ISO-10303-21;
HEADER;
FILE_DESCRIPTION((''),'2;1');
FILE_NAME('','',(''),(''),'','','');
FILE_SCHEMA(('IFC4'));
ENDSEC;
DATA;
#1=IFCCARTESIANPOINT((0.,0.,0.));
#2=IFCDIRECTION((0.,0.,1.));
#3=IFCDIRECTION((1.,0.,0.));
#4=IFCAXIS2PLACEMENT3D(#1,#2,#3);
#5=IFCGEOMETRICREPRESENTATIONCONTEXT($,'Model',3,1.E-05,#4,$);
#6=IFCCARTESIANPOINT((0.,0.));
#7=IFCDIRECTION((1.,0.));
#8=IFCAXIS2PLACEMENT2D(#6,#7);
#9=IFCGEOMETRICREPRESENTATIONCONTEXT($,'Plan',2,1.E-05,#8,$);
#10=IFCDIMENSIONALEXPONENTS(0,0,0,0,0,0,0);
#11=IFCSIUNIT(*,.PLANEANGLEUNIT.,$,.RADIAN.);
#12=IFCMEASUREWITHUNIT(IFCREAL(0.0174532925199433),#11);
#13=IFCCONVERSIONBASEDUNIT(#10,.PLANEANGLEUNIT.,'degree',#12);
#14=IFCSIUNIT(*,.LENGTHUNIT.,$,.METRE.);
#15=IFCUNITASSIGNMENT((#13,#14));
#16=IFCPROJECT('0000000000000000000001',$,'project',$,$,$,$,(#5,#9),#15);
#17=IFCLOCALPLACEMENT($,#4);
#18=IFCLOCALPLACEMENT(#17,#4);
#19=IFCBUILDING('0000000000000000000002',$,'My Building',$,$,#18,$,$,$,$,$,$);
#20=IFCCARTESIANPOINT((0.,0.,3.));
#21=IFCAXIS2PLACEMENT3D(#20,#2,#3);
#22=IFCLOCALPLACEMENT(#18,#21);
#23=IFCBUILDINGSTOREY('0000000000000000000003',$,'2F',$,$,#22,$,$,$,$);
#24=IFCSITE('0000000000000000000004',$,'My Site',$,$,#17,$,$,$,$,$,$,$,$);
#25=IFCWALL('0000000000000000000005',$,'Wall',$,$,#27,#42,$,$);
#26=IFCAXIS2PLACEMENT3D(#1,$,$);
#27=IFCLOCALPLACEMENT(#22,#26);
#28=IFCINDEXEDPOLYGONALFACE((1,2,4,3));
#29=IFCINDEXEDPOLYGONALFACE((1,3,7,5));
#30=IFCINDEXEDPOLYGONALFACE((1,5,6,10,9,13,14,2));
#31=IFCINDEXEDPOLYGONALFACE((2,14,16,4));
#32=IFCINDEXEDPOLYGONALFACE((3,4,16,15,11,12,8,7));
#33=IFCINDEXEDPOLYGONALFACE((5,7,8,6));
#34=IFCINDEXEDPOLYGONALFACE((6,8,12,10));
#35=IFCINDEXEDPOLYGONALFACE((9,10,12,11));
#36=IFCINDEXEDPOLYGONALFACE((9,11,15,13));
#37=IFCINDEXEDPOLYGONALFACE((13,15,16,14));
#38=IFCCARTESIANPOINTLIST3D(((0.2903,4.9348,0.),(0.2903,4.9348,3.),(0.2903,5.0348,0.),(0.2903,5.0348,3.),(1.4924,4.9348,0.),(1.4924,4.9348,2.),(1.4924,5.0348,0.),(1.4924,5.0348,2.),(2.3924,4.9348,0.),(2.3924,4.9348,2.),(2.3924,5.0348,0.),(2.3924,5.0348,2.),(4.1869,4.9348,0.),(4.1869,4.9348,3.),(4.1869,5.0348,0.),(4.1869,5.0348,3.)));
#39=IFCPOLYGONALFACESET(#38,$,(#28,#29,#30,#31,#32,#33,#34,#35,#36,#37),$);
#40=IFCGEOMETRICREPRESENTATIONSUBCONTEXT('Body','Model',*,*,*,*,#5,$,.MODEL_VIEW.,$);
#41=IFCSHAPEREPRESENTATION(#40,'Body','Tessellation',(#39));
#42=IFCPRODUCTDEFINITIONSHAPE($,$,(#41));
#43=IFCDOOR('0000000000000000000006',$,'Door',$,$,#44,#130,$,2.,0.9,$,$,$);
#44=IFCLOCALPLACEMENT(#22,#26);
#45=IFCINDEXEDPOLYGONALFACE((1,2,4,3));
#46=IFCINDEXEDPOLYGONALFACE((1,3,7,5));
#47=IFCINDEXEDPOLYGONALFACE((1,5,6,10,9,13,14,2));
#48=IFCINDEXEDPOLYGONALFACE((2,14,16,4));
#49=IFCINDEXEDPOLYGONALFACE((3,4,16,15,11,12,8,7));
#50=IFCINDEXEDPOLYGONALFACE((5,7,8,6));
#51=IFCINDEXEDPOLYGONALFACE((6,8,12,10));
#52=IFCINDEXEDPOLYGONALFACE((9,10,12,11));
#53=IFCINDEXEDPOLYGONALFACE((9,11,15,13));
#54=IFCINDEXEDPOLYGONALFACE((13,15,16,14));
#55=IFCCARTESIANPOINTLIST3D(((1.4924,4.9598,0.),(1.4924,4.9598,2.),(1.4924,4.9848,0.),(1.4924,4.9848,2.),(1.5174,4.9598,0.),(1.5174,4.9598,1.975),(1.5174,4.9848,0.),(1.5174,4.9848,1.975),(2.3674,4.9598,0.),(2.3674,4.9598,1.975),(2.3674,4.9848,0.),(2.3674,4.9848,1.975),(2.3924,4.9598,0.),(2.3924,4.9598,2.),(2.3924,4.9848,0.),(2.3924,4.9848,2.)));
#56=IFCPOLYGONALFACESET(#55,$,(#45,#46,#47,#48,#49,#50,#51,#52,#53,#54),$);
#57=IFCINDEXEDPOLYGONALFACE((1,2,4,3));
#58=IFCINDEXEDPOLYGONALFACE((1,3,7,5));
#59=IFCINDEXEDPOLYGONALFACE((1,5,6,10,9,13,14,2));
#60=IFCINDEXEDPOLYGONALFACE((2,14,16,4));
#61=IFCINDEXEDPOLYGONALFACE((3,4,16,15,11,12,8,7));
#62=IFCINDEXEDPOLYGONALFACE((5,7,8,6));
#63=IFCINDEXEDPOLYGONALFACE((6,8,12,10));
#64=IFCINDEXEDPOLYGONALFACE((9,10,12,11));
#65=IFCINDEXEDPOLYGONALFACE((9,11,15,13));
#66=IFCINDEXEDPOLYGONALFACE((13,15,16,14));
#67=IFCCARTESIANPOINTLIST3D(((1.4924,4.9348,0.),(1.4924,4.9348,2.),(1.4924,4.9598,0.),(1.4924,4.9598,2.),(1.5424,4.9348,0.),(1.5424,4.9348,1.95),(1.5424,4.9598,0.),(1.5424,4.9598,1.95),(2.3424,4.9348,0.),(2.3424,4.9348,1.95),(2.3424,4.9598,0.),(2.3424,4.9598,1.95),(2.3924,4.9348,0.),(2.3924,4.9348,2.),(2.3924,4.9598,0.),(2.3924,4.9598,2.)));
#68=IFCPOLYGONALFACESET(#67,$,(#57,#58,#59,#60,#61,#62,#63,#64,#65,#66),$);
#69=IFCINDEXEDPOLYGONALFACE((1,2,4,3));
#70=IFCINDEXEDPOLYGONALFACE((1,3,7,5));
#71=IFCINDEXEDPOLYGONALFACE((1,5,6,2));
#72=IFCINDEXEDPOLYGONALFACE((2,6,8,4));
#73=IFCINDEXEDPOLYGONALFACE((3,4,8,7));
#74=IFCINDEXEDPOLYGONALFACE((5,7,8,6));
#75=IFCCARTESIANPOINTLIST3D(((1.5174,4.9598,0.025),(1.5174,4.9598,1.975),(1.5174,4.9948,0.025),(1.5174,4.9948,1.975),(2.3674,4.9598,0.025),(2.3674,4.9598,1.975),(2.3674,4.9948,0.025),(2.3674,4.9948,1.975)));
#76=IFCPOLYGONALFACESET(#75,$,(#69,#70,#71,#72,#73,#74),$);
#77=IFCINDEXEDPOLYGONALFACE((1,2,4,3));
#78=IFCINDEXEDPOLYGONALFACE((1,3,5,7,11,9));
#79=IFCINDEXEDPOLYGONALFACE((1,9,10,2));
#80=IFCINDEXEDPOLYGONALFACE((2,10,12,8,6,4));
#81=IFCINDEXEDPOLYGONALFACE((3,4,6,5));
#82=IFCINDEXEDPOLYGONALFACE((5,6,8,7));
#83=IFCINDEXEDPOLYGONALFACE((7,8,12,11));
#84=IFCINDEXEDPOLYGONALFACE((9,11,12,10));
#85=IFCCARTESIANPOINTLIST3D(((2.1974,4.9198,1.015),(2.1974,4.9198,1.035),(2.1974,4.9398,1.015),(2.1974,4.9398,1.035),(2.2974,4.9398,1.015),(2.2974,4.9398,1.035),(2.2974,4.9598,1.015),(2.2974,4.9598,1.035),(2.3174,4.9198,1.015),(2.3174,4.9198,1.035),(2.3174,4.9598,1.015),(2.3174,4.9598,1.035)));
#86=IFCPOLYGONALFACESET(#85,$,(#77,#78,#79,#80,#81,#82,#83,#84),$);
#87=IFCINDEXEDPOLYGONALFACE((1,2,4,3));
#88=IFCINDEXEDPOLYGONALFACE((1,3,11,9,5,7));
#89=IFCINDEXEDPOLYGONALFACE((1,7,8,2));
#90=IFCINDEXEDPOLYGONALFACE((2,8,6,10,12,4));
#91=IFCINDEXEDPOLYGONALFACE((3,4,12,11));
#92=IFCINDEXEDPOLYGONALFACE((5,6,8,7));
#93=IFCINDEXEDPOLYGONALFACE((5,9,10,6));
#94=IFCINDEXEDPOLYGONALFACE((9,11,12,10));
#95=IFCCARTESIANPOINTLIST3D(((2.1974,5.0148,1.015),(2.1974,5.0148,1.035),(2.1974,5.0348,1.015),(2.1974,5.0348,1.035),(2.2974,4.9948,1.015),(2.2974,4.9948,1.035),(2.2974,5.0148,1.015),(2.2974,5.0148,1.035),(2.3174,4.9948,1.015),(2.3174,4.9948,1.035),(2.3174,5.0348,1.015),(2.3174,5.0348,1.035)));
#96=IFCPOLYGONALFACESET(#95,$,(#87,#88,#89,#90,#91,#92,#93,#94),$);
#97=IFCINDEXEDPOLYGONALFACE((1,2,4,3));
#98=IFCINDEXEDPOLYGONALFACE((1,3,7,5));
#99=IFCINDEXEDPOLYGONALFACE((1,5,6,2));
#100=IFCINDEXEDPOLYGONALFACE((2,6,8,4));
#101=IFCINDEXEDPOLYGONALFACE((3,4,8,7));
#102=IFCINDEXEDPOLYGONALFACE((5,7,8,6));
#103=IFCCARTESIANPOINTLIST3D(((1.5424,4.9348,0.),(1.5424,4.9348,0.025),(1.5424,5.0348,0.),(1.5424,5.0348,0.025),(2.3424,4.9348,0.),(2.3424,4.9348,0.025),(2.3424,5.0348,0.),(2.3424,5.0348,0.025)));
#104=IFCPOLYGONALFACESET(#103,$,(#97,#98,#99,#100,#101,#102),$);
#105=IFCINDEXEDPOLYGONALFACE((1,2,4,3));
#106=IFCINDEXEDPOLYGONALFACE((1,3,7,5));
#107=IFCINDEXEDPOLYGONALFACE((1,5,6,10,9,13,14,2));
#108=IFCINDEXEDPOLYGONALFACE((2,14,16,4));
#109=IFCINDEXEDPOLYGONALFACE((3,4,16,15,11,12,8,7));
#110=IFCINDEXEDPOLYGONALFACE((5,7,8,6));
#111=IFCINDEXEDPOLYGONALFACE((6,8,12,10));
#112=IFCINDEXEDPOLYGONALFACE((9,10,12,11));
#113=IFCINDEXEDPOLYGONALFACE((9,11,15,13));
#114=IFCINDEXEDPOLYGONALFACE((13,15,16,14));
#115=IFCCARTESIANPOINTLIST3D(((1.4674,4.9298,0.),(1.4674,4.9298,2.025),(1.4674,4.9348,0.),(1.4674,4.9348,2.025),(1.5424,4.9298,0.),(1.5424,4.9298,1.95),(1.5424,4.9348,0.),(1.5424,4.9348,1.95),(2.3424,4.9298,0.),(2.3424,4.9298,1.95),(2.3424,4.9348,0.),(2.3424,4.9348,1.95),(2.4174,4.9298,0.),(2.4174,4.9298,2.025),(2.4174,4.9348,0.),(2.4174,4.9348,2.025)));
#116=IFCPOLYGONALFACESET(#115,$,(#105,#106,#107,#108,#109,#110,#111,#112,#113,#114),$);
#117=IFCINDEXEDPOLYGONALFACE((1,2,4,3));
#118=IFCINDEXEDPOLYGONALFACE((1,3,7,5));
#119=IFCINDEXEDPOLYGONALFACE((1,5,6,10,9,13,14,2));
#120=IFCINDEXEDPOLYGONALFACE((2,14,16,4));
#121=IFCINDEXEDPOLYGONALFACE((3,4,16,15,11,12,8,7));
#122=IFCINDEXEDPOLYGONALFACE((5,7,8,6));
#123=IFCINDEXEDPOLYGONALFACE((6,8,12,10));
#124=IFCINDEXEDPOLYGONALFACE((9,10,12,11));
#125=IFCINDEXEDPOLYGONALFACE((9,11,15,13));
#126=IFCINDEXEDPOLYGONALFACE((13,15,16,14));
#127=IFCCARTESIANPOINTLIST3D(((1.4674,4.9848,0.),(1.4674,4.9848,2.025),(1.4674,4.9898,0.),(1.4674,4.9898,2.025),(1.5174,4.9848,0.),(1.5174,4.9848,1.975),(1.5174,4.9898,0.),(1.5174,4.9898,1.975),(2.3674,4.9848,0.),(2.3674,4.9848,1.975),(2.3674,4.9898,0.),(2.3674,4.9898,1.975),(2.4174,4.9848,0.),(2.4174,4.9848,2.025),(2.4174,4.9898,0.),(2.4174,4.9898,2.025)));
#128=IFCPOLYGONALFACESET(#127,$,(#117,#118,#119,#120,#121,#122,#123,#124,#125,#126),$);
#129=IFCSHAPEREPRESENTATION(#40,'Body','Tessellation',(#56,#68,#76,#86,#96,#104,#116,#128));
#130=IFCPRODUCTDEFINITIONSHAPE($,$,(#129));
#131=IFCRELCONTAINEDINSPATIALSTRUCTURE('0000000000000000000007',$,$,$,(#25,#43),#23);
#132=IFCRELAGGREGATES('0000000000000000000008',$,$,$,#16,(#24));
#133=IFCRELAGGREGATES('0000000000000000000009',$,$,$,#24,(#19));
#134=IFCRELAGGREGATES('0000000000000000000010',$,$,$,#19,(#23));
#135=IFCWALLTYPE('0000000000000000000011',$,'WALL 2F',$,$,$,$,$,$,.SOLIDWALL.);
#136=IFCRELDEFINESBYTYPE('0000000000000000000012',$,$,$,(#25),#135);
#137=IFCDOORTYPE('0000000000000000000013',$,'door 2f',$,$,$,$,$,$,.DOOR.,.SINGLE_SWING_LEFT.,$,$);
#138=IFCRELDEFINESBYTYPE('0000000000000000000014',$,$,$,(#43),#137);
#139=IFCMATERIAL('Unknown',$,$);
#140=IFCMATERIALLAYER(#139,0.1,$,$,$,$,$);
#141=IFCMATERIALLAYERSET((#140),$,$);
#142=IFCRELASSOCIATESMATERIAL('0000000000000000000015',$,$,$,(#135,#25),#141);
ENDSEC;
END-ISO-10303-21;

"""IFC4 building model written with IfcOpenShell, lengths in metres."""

from ifc_helpers import new_model, entity, si_unit, converted_unit, frame, origin_with_axes, origin_2d_with_axis, place, context, subcontext, project, spatial, line, indexed_curve, outline, extrude, shape, source, transform, mapped, material, layer, layer_set, layer_usage, type_object, type_shapes, element, fill, save


model = new_model("IFC4")

# Units and contexts
model_context = context("Model", 3, precision=1e-05, world=origin_with_axes())
plan_context = context("Plan", 2, precision=1e-05, world=origin_2d_with_axis())
body_context_1 = subcontext(model_context, "Body", "Model", "MODEL_VIEW")
body_context_2 = subcontext(plan_context, "Body", "Plan", "PLAN_VIEW")
ifc_project = project(units=[converted_unit("PLANEANGLEUNIT", "degree", entity("IfcReal", 0.0174532925199433), si_unit("PLANEANGLEUNIT", "RADIAN"), dimensions=[0, 0, 0, 0, 0, 0, 0]), si_unit("LENGTHUNIT", "METRE")], contexts=[model_context, plan_context])

# Site, building, storey
site_placement = place(None, origin_with_axes())
site = spatial("IfcSite", under=ifc_project, at=site_placement, Name="My Site")
building_placement = place(site_placement, origin_with_axes())
building = spatial("IfcBuilding", under=site, at=building_placement, Name="My Building")
storey_placement = place(building_placement, frame((0.0, 0.0, 3.0), z_axis=(0.0, 0.0, 1.0), x_axis=(1.0, 0.0, 0.0)))
storey = spatial("IfcBuildingStorey", under=building, at=storey_placement, Name="2F")

# Shared definitions
ifc_material = material(Name="Unknown")

# Shared definitions
ifc_layer_1 = layer(ifc_material, 0.1)
ifc_layer_set_1 = layer_set([ifc_layer_1])
wall_type = type_object("IfcWallType", Name="WALL 2F", PredefinedType="SOLIDWALL", material=ifc_layer_set_1)

# Wall, opening, door
ifc_layer_usage_1 = layer_usage(ifc_layer_set_1, "AXIS2", "POSITIVE", 0.0)
wall_1_placement = place(storey_placement, frame((0.2903, 4.9348, 0.0), z_axis=(0.0, 0.0, 1.0), x_axis=(1.0, 0.0, 0.0)))
wall_1 = element("IfcWall", 1, at=wall_1_placement, inside=storey, type_object=wall_type, material=ifc_layer_usage_1, Name="Wall", context=body_context_1, shape_type="SweptSolid", body=[
    extrude(outline(indexed_curve([(0.0, 0.0), (0.0, 0.1), (3.8966, 0.1), (3.8966, 0.0)], segments=[line(1, 2, 3, 4, 1)])), origin_with_axes(), (0.0, 0.0, 1.0), 3.0),
])
shared_shape_1 = source(origin_with_axes(), body_context_1, "Body", "SweptSolid", [
    extrude(outline(indexed_curve([(0.0, 0.0), (0.9, 0.0), (0.9, 2.0), (0.0, 2.0)], segments=[line(1, 2, 3, 4, 1)])), frame((0.0, -0.6, 0.0), z_axis=(0.0, -1.0, 0.0), x_axis=(1.0, 0.0, 0.0)), (0.0, 0.0, -1.0), 1.2),
])
opening_1_placement = place(wall_1_placement, frame((1.2022, 0.0, 0.0), z_axis=(0.0, 0.0, 1.0), x_axis=(1.0, 0.0, 0.0)))
opening_1 = element("IfcOpeningElement", 2, at=opening_1_placement, cuts=wall_1, PredefinedType="OPENING", context=body_context_1, shape_type="MappedRepresentation", body=[
    mapped(shared_shape_1, transform((0.0, 0.0, 0.0), x_axis=(1.0, 0.0, 0.0), y_axis=(0.0, 1.0, 0.0), z_axis=(0.0, 0.0, 1.0), scale=1.0)),
])
door_type = type_object("IfcDoorType", Name="door 2f", OperationType="SINGLE_SWING_LEFT", PredefinedType="DOOR")
shared_shape_2 = source(origin_with_axes(), body_context_1, "Body", "SweptSolid", [
    extrude(outline(indexed_curve([(0.0, 0.0), (0.0, 2.0), (0.9, 2.0), (0.9, 0.0), (0.875, 0.0), (0.875, 1.975), (0.025, 1.975), (0.025, 0.0)], segments=[line(1, 2, 3, 4, 5, 6, 7, 8, 1)])), frame((0.0, 0.025, 0.0), z_axis=(0.0, -1.0, 0.0), x_axis=(1.0, 0.0, 0.0)), (0.0, 0.0, -1.0), 0.025),
    extrude(outline(indexed_curve([(0.0, 0.0), (0.0, 2.0), (0.9, 2.0), (0.9, 0.0), (0.85, 0.0), (0.85, 1.95), (0.05, 1.95), (0.05, 0.0)], segments=[line(1, 2, 3, 4, 5, 6, 7, 8, 1)])), frame((0.0, 0.0, 0.0), z_axis=(0.0, -1.0, 0.0), x_axis=(1.0, 0.0, 0.0)), (0.0, 0.0, -1.0), 0.025),
    extrude(outline(indexed_curve([(0.0, 0.0), (0.85, 0.0), (0.85, 0.035), (0.0, 0.035)], segments=[line(1, 2, 3, 4, 1)])), frame((0.025, 0.025, 0.025), z_axis=(0.0, 0.0, 1.0), x_axis=(1.0, 0.0, 0.0)), (0.0, 0.0, 1.0), 1.95),
    extrude(outline(indexed_curve([(0.0, 0.0), (0.0, -0.04), (-0.12, -0.04), (-0.12, -0.02), (-0.02, -0.02), (-0.02, 0.0)], segments=[line(1, 2, 3, 4, 5, 6, 1)])), frame((0.825, 0.025, 1.015), z_axis=(0.0, 0.0, 1.0), x_axis=(1.0, 0.0, 0.0)), (0.0, 0.0, 1.0), 0.02),
    extrude(outline(indexed_curve([(0.0, 0.0), (0.0, 0.04), (-0.12, 0.04), (-0.12, 0.02), (-0.02, 0.02), (-0.02, 0.0)], segments=[line(1, 2, 3, 4, 5, 6, 1)])), frame((0.825, 0.06, 1.015), z_axis=(0.0, 0.0, 1.0), x_axis=(1.0, 0.0, 0.0)), (0.0, 0.0, 1.0), 0.02),
    extrude(outline(indexed_curve([(0.0, 0.0), (0.8, 0.0), (0.8, 0.1), (0.0, 0.1)], segments=[line(1, 2, 3, 4, 1)])), frame((0.05, 0.0, 0.0), z_axis=(0.0, 0.0, 1.0), x_axis=(1.0, 0.0, 0.0)), (0.0, 0.0, 1.0), 0.025),
    extrude(outline(indexed_curve([(0.0, 0.0), (0.0, 2.025), (0.95, 2.025), (0.95, 0.0), (0.875, 0.0), (0.875, 1.95), (0.075, 1.95), (0.075, 0.0)], segments=[line(1, 2, 3, 4, 5, 6, 7, 8, 1)])), frame((-0.025, -0.005, 0.0), z_axis=(0.0, -1.0, 0.0), x_axis=(1.0, 0.0, 0.0)), (0.0, 0.0, -1.0), 0.005),
    extrude(outline(indexed_curve([(0.0, 0.0), (0.0, 2.025), (0.95, 2.025), (0.95, 0.0), (0.9, 0.0), (0.9, 1.975), (0.05, 1.975), (0.05, 0.0)], segments=[line(1, 2, 3, 4, 5, 6, 7, 8, 1)])), frame((-0.025, 0.05, 0.0), z_axis=(0.0, -1.0, 0.0), x_axis=(1.0, 0.0, 0.0)), (0.0, 0.0, -1.0), 0.005),
])
shared_shape_3 = source(origin_with_axes(), body_context_2, "Body", "Curve2D", [
    entity("IfcIndexedPolyCurve", entity("IfcCartesianPointList2D", [[0.0, 0.0], [0.0, 0.05], [0.025, 0.05], [0.025, 0.025], [0.05, 0.025], [0.05, 0.0]]), [entity("IfcLineIndex", [1, 2, 3, 4, 5, 6, 1])]),
    entity("IfcIndexedPolyCurve", entity("IfcCartesianPointList2D", [[0.9, 0.0], [0.9, 0.05], [0.875, 0.05], [0.875, 0.025], [0.85, 0.025], [0.85, 0.0]]), [entity("IfcLineIndex", [1, 2, 3, 4, 5, 6, 1])]),
    entity("IfcTrimmedCurve", entity("IfcEllipse", entity("IfcAxis2Placement2D", entity("IfcCartesianPoint", [0.06, 0.05]), entity("IfcDirection", [1.0, 0.0])), 0.815, 0.85), [entity("IfcCartesianPoint", [0.875, 0.05])], [entity("IfcCartesianPoint", [0.06, 0.9])], True, "CARTESIAN"),
    entity("IfcIndexedPolyCurve", entity("IfcCartesianPointList2D", [[0.025, 0.05], [0.06, 0.05], [0.06, 0.9], [0.025, 0.9]]), [entity("IfcLineIndex", [1, 2, 3, 4, 1])]),
])
type_shapes(door_type, [shared_shape_2, shared_shape_3])
door_placement = place(opening_1_placement, origin_with_axes())
door = element("IfcDoor", 3, at=door_placement, inside=storey, type_object=door_type, Name="Door", OverallHeight=2.0, OverallWidth=0.9, shapes=[
    shape(body_context_1, "Body", "MappedRepresentation", [mapped(shared_shape_2, transform((0.0, 0.0, 0.0), x_axis=(1.0, 0.0, 0.0), y_axis=(0.0, 1.0, 0.0), z_axis=(0.0, 0.0, 1.0), scale=1.0))]),
    shape(body_context_2, "Body", "MappedRepresentation", [mapped(shared_shape_3, transform((0.0, 0.0, 0.0), x_axis=(1.0, 0.0, 0.0), y_axis=(0.0, 1.0, 0.0), z_axis=(0.0, 0.0, 1.0), scale=1.0))]),
])
fill(opening_1, door)

save(model, "model.ifc")
